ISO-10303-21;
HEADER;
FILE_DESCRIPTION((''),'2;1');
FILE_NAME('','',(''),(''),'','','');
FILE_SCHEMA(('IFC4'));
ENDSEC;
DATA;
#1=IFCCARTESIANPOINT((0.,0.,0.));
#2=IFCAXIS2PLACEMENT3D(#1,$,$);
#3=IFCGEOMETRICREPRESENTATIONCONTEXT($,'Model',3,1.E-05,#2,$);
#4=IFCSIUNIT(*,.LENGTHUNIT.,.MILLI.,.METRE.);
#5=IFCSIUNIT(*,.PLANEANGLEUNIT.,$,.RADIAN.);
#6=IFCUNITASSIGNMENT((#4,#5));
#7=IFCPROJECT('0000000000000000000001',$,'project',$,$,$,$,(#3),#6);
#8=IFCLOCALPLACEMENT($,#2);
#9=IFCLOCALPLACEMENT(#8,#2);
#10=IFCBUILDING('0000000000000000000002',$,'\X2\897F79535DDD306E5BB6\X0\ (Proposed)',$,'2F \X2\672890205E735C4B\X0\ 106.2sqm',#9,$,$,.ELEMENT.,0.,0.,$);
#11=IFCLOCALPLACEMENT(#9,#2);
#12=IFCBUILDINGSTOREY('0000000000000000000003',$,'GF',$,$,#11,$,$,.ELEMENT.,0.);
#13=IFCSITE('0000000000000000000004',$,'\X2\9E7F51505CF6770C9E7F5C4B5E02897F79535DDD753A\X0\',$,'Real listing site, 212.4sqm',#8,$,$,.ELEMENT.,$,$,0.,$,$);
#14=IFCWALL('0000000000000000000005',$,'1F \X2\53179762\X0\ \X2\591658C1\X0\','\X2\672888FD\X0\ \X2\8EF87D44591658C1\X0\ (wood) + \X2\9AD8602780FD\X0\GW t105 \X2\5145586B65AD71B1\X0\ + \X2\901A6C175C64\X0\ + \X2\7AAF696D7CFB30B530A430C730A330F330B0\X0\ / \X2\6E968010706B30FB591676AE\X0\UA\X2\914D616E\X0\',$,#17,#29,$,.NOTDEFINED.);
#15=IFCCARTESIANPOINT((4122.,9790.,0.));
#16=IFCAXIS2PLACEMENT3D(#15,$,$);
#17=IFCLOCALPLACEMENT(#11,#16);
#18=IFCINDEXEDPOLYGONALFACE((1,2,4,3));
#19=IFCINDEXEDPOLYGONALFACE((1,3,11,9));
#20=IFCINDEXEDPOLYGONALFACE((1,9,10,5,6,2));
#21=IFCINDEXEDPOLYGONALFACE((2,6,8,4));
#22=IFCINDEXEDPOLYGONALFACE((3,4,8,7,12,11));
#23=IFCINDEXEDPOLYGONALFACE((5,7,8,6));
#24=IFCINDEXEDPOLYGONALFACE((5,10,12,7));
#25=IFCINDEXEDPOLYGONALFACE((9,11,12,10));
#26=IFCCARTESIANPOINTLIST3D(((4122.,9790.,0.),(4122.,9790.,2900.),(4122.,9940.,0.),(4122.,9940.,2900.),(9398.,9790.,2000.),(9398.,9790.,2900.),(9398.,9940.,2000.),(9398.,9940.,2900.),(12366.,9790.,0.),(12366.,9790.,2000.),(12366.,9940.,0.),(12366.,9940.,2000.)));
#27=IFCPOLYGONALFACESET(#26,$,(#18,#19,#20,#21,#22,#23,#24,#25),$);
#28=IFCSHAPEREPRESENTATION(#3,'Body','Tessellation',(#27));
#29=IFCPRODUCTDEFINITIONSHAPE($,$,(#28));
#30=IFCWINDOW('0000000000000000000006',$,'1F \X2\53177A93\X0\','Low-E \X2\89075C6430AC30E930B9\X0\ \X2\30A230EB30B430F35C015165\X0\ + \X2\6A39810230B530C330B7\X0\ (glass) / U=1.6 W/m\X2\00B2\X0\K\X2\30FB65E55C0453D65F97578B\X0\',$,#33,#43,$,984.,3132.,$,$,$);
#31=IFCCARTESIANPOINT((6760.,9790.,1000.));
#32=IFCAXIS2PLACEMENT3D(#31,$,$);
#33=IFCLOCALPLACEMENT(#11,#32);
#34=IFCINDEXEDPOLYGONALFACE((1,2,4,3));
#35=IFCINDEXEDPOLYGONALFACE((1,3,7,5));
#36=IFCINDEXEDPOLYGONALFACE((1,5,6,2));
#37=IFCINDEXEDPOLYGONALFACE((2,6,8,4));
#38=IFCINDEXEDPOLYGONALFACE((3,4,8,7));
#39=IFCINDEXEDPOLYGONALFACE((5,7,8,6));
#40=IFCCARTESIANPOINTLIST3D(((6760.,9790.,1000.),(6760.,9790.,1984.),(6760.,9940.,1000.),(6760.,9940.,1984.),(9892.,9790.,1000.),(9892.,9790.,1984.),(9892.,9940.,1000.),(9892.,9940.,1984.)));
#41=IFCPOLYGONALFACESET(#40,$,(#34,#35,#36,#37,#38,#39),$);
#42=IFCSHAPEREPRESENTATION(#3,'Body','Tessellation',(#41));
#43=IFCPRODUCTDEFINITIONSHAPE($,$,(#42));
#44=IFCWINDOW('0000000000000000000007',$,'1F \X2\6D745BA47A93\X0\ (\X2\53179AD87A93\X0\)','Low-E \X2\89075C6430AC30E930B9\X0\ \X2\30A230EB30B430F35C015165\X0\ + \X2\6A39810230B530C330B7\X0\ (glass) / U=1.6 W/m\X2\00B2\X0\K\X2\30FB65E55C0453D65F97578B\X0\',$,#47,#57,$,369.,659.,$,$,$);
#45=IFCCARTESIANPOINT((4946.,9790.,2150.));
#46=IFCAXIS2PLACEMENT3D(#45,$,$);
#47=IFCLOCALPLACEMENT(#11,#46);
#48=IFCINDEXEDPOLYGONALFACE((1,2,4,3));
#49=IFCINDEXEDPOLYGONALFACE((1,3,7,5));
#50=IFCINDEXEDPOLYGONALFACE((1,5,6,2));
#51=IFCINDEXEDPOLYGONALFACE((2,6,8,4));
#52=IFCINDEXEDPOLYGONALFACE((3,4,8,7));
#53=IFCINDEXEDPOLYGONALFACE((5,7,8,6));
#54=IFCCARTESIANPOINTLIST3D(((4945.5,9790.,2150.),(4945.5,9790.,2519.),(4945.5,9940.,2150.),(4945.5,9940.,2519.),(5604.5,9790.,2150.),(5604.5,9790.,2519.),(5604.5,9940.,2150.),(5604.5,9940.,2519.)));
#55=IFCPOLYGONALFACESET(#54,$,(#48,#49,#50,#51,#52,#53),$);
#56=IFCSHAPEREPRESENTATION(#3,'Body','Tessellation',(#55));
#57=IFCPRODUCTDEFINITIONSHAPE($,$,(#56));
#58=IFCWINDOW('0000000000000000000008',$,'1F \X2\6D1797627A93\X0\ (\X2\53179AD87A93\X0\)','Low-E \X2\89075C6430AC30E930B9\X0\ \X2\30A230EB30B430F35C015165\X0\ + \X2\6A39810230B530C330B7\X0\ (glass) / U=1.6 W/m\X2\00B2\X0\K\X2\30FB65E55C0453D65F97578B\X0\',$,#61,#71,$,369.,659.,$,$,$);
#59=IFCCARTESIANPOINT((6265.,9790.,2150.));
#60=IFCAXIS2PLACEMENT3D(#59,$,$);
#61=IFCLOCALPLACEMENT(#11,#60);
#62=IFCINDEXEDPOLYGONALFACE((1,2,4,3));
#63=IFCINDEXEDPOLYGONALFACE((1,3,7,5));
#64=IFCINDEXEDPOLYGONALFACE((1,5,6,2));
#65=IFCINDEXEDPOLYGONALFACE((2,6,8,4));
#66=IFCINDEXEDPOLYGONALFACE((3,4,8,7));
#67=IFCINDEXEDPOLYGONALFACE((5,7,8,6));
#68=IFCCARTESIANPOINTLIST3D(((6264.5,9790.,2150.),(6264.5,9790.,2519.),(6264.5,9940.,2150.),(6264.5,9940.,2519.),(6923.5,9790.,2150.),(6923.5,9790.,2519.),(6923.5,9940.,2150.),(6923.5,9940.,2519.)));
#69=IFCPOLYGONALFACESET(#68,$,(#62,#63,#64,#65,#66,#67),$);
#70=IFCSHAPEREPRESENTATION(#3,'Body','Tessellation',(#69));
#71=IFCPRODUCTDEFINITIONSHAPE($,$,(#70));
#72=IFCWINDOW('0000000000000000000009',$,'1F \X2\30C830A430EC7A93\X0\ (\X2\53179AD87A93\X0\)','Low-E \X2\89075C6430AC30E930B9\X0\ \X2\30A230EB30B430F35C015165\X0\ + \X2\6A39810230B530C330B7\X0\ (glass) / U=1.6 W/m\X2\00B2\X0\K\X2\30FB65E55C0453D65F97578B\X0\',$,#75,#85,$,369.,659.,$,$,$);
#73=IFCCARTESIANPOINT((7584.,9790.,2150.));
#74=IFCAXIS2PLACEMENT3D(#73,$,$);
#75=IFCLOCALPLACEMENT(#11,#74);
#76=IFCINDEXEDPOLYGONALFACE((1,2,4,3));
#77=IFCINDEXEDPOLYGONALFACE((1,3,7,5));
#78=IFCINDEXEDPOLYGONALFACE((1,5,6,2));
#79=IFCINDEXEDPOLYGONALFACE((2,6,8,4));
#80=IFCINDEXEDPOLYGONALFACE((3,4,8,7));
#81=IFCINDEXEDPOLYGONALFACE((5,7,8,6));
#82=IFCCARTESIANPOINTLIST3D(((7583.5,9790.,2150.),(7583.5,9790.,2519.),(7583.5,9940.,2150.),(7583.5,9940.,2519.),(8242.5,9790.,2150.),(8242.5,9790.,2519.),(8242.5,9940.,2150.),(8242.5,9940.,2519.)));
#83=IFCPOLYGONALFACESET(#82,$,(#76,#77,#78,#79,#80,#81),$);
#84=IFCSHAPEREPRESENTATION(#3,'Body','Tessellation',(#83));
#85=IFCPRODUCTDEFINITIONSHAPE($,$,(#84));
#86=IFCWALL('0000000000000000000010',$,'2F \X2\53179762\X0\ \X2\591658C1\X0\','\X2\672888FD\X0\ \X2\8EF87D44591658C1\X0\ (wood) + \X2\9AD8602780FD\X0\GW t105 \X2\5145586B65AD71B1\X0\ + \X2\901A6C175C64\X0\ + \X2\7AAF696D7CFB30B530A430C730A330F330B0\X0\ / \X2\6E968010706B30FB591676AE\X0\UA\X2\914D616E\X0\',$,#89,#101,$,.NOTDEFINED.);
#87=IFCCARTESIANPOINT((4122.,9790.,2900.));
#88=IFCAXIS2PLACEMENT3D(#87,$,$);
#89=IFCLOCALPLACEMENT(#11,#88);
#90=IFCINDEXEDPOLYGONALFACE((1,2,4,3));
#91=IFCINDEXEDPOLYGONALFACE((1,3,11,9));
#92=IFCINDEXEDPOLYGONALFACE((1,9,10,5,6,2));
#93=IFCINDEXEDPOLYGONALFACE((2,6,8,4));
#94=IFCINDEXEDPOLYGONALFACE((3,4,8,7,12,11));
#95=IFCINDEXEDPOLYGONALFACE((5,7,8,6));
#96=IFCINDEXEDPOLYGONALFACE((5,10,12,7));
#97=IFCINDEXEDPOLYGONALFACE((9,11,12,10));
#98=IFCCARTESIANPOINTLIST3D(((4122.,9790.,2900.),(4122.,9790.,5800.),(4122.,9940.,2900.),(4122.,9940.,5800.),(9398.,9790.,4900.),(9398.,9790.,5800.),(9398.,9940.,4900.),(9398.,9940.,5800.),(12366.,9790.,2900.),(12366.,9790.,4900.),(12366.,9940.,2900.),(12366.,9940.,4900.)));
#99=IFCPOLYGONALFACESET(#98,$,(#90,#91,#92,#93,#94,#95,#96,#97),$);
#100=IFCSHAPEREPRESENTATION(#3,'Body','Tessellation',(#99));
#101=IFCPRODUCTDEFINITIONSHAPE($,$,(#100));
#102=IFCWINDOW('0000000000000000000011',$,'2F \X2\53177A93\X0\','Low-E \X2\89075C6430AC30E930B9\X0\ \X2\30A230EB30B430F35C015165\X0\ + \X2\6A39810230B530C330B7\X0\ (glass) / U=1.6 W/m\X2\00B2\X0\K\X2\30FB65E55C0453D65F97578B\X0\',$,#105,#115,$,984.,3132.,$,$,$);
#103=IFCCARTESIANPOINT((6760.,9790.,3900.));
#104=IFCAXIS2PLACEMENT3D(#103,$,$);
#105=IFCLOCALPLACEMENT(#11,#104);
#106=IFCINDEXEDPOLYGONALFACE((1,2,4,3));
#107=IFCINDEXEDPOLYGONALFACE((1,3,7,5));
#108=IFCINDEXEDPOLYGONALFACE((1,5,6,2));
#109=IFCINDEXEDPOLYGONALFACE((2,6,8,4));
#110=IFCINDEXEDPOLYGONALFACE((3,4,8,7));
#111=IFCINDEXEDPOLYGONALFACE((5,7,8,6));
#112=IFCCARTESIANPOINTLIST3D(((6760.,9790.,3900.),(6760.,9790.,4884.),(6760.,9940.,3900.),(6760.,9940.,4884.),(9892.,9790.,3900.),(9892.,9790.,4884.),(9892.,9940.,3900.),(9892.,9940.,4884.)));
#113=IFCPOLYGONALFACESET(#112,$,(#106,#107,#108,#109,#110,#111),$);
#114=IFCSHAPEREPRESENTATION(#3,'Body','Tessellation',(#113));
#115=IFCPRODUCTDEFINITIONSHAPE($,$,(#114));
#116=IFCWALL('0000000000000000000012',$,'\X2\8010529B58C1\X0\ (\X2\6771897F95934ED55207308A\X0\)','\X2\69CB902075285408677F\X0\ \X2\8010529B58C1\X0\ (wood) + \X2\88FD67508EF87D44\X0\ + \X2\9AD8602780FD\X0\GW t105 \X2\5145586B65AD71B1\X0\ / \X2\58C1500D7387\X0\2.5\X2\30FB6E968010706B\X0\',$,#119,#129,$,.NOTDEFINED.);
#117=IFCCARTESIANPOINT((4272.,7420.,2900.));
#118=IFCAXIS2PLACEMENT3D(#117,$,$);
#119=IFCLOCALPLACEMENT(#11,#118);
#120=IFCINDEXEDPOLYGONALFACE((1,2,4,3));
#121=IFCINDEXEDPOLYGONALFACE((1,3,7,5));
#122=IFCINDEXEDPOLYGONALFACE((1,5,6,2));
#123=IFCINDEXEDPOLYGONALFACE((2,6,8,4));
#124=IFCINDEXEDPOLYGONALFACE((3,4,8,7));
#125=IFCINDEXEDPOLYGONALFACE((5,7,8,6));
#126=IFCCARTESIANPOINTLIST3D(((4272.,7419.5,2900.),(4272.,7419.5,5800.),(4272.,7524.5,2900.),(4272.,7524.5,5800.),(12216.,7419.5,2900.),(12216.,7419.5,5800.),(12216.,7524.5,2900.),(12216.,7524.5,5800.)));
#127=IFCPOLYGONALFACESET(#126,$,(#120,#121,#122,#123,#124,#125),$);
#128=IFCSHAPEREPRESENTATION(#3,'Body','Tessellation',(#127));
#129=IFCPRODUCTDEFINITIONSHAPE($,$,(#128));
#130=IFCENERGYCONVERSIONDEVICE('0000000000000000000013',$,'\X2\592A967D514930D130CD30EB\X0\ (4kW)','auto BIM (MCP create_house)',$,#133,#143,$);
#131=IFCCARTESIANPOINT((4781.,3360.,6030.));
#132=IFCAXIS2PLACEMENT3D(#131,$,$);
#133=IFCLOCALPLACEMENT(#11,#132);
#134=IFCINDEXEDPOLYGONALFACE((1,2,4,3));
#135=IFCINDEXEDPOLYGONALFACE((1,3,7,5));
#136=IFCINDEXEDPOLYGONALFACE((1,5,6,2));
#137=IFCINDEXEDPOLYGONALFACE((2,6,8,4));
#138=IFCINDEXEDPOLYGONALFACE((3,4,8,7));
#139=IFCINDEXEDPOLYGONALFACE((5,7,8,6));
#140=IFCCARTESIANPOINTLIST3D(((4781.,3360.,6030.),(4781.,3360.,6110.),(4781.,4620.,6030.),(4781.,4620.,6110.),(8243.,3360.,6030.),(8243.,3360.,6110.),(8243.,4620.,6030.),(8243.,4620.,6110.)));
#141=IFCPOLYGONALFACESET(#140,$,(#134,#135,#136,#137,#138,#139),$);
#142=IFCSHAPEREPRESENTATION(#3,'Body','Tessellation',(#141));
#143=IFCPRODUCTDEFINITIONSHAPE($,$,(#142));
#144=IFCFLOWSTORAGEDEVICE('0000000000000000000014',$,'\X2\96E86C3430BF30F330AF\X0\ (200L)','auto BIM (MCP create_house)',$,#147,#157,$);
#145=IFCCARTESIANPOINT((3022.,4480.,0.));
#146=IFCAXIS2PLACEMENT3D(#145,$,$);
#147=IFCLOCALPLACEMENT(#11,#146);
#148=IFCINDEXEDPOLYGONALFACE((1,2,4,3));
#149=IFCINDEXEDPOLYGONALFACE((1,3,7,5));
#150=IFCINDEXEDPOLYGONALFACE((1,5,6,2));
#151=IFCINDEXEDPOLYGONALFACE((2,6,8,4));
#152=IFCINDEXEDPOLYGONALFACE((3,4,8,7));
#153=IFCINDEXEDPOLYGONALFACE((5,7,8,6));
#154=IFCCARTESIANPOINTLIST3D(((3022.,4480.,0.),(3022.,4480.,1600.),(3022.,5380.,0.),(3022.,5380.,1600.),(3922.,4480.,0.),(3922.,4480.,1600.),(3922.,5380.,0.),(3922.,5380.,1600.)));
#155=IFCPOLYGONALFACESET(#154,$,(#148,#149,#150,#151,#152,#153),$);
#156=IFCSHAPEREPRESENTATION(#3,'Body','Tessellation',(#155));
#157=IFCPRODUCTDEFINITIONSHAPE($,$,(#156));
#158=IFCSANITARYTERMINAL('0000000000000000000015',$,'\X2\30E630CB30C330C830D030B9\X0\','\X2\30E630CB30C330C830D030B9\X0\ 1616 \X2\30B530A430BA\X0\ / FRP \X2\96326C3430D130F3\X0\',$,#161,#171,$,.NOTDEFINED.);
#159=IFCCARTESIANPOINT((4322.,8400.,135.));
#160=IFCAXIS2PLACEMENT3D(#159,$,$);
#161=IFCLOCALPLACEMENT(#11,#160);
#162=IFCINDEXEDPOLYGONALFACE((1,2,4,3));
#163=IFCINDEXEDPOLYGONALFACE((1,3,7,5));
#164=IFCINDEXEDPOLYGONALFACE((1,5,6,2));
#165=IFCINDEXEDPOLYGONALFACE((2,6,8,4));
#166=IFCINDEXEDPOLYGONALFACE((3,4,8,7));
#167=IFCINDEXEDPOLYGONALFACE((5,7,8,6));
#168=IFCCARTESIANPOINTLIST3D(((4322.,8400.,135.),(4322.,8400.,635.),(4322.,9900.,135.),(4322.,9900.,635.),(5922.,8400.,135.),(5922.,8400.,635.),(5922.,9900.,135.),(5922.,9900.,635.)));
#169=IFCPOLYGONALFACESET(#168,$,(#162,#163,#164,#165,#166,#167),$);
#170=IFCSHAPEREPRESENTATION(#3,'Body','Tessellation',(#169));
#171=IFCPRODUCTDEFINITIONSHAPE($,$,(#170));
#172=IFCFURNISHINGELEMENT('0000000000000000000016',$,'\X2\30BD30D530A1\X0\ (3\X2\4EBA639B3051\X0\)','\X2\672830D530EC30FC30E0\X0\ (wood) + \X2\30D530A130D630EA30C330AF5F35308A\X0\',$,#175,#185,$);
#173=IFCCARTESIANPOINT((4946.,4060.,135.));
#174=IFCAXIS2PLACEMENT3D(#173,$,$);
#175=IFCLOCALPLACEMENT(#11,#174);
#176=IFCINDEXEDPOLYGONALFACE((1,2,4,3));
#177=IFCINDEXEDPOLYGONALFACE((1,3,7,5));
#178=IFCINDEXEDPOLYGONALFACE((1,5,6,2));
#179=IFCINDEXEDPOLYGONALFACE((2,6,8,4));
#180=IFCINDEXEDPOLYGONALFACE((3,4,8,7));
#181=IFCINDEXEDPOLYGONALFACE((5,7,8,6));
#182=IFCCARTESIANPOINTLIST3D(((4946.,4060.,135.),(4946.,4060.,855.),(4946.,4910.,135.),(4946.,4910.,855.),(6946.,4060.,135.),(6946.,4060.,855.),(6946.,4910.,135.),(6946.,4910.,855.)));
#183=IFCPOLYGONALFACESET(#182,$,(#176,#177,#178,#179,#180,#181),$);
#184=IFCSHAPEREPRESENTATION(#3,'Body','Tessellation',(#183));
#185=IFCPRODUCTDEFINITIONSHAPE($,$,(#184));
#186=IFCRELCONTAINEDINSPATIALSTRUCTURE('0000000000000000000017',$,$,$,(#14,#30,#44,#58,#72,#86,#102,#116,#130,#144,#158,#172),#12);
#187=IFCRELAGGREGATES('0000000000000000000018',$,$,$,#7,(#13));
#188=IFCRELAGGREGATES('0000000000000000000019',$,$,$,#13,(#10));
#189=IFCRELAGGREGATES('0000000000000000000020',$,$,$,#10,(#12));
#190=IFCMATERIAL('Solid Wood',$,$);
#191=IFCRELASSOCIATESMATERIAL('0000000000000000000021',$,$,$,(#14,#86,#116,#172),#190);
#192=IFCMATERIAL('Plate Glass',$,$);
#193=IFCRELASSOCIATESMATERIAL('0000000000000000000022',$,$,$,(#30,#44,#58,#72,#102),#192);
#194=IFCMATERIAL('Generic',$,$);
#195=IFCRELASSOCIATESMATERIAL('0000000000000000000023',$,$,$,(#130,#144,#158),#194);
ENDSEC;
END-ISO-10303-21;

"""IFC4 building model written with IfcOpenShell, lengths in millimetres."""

from ifc_helpers import new_model, si_unit, frame, frame_2d, origin, place, context, project, spatial, rectangle, extrude, material, element, fill, save


model = new_model("IFC4")

# Units and contexts
model_context = context("Model", 3, precision=1e-05, world=origin())
ifc_project = project(units=[si_unit("LENGTHUNIT", "METRE", prefix="MILLI"), si_unit("PLANEANGLEUNIT", "RADIAN")], contexts=[model_context])

# Site, building, storey
site_placement = place(None, origin())
site = spatial("IfcSite", under=ifc_project, at=site_placement, Name="鹿児島県鹿屋市西祓川町", ObjectType="Real listing site, 212.4sqm", CompositionType="ELEMENT", RefElevation=0.0)
building_placement = place(site_placement, origin())
building = spatial("IfcBuilding", under=site, at=building_placement, Name="西祓川の家 (Proposed)", ObjectType="2F 木造平屋 106.2sqm", CompositionType="ELEMENT", ElevationOfRefHeight=0.0, ElevationOfTerrain=0.0)
storey_placement = place(building_placement, origin())
storey = spatial("IfcBuildingStorey", under=building, at=storey_placement, Name="GF", CompositionType="ELEMENT", Elevation=0.0)

# Wall, openings, windows
ifc_material_1 = material(Name="Solid Wood")
wall_1_placement = place(storey_placement, frame((4122.0, 9790.0, 0.0)))
wall_1 = element("IfcWall", 1, at=wall_1_placement, inside=storey, material=ifc_material_1, Name="1F 北面 外壁", Description="木製 軸組外壁 (wood) + 高性能GW t105 充填断熱 + 通気層 + 窯業系サイディング / 準耐火・外皮UA配慮", PredefinedType="NOTDEFINED", context=model_context, shape_type="SweptSolid", body=[
    extrude(rectangle(XDim=8244.0, YDim=150.0, at=frame_2d((4122.0, 75.0))), frame((4122.0, 9790.0, 0.0)), (0.0, 0.0, 1.0), 2900.0),
])
opening_1_placement = place(storey_placement, frame((6760.0, 9790.0, 1000.0)))
opening_1 = element("IfcOpeningElement", 2, at=opening_1_placement, cuts=wall_1, PredefinedType="NOTDEFINED", context=model_context, shape_type="SweptSolid", body=[
    extrude(rectangle(XDim=3132.0, YDim=150.0, at=frame_2d((1566.0, 75.0))), frame((6760.0, 9790.0, 1000.0)), (0.0, 0.0, 1.0), 984.0),
])
opening_2_placement = place(storey_placement, frame((4946.0, 9790.0, 2150.0)))
opening_2 = element("IfcOpeningElement", 3, at=opening_2_placement, cuts=wall_1, PredefinedType="NOTDEFINED", context=model_context, shape_type="SweptSolid", body=[
    extrude(rectangle(XDim=659.0, YDim=150.0, at=frame_2d((329.0, 75.0))), frame((4946.0, 9790.0, 2150.0)), (0.0, 0.0, 1.0), 369.0),
])
opening_3_placement = place(storey_placement, frame((6265.0, 9790.0, 2150.0)))
opening_3 = element("IfcOpeningElement", 4, at=opening_3_placement, cuts=wall_1, PredefinedType="NOTDEFINED", context=model_context, shape_type="SweptSolid", body=[
    extrude(rectangle(XDim=659.0, YDim=150.0, at=frame_2d((329.0, 75.0))), frame((6265.0, 9790.0, 2150.0)), (0.0, 0.0, 1.0), 369.0),
])
opening_4_placement = place(storey_placement, frame((7584.0, 9790.0, 2150.0)))
opening_4 = element("IfcOpeningElement", 5, at=opening_4_placement, cuts=wall_1, PredefinedType="NOTDEFINED", context=model_context, shape_type="SweptSolid", body=[
    extrude(rectangle(XDim=659.0, YDim=150.0, at=frame_2d((329.0, 75.0))), frame((7584.0, 9790.0, 2150.0)), (0.0, 0.0, 1.0), 369.0),
])
ifc_material_2 = material(Name="Plate Glass")
window_1_placement = place(storey_placement, frame((6760.0, 9790.0, 1000.0)))
window_1 = element("IfcWindow", 6, at=window_1_placement, inside=storey, material=ifc_material_2, Name="1F 北窓", Description="Low-E 複層ガラス アルゴン封入 + 樹脂サッシ (glass) / U=1.6 W/m²K・日射取得型", OverallHeight=984.0, OverallWidth=3132.0, context=model_context, shape_type="SweptSolid", body=[
    extrude(rectangle(XDim=3132.0, YDim=150.0, at=frame_2d((1566.0, 75.0))), frame((6760.0, 9790.0, 1000.0)), (0.0, 0.0, 1.0), 984.0),
])
fill(opening_1, window_1)
window_2_placement = place(storey_placement, frame((4946.0, 9790.0, 2150.0)))
window_2 = element("IfcWindow", 7, at=window_2_placement, inside=storey, material=ifc_material_2, Name="1F 浴室窓 (北高窓)", Description="Low-E 複層ガラス アルゴン封入 + 樹脂サッシ (glass) / U=1.6 W/m²K・日射取得型", OverallHeight=369.0, OverallWidth=659.0, context=model_context, shape_type="SweptSolid", body=[
    extrude(rectangle(XDim=659.0, YDim=150.0, at=frame_2d((329.0, 75.0))), frame((4946.0, 9790.0, 2150.0)), (0.0, 0.0, 1.0), 369.0),
])
fill(opening_2, window_2)
window_3_placement = place(storey_placement, frame((6265.0, 9790.0, 2150.0)))
window_3 = element("IfcWindow", 8, at=window_3_placement, inside=storey, material=ifc_material_2, Name="1F 洗面窓 (北高窓)", Description="Low-E 複層ガラス アルゴン封入 + 樹脂サッシ (glass) / U=1.6 W/m²K・日射取得型", OverallHeight=369.0, OverallWidth=659.0, context=model_context, shape_type="SweptSolid", body=[
    extrude(rectangle(XDim=659.0, YDim=150.0, at=frame_2d((329.0, 75.0))), frame((6265.0, 9790.0, 2150.0)), (0.0, 0.0, 1.0), 369.0),
])
fill(opening_3, window_3)
window_4_placement = place(storey_placement, frame((7584.0, 9790.0, 2150.0)))
window_4 = element("IfcWindow", 9, at=window_4_placement, inside=storey, material=ifc_material_2, Name="1F トイレ窓 (北高窓)", Description="Low-E 複層ガラス アルゴン封入 + 樹脂サッシ (glass) / U=1.6 W/m²K・日射取得型", OverallHeight=369.0, OverallWidth=659.0, context=model_context, shape_type="SweptSolid", body=[
    extrude(rectangle(XDim=659.0, YDim=150.0, at=frame_2d((329.0, 75.0))), frame((7584.0, 9790.0, 2150.0)), (0.0, 0.0, 1.0), 369.0),
])
fill(opening_4, window_4)

# Wall, opening, window
wall_2_placement = place(storey_placement, frame((4122.0, 9790.0, 2900.0)))
wall_2 = element("IfcWall", 10, at=wall_2_placement, inside=storey, material=ifc_material_1, Name="2F 北面 外壁", Description="木製 軸組外壁 (wood) + 高性能GW t105 充填断熱 + 通気層 + 窯業系サイディング / 準耐火・外皮UA配慮", PredefinedType="NOTDEFINED", context=model_context, shape_type="SweptSolid", body=[
    extrude(rectangle(XDim=8244.0, YDim=150.0, at=frame_2d((4122.0, 75.0))), frame((4122.0, 9790.0, 2900.0)), (0.0, 0.0, 1.0), 2900.0),
])
opening_5_placement = place(storey_placement, frame((6760.0, 9790.0, 3900.0)))
opening_5 = element("IfcOpeningElement", 11, at=opening_5_placement, cuts=wall_2, PredefinedType="NOTDEFINED", context=model_context, shape_type="SweptSolid", body=[
    extrude(rectangle(XDim=3132.0, YDim=150.0, at=frame_2d((1566.0, 75.0))), frame((6760.0, 9790.0, 3900.0)), (0.0, 0.0, 1.0), 984.0),
])
window_5_placement = place(storey_placement, frame((6760.0, 9790.0, 3900.0)))
window_5 = element("IfcWindow", 12, at=window_5_placement, inside=storey, material=ifc_material_2, Name="2F 北窓", Description="Low-E 複層ガラス アルゴン封入 + 樹脂サッシ (glass) / U=1.6 W/m²K・日射取得型", OverallHeight=984.0, OverallWidth=3132.0, context=model_context, shape_type="SweptSolid", body=[
    extrude(rectangle(XDim=3132.0, YDim=150.0, at=frame_2d((1566.0, 75.0))), frame((6760.0, 9790.0, 3900.0)), (0.0, 0.0, 1.0), 984.0),
])
fill(opening_5, window_5)

# Wall
wall_3_placement = place(storey_placement, frame((4272.0, 7420.0, 2900.0)))
element("IfcWall", 13, at=wall_3_placement, inside=storey, material=ifc_material_1, Name="耐力壁 (東西間仕切り)", Description="構造用合板 耐力壁 (wood) + 製材軸組 + 高性能GW t105 充填断熱 / 壁倍率2.5・準耐火", PredefinedType="NOTDEFINED", context=model_context, shape_type="SweptSolid", body=[
    extrude(rectangle(XDim=7944.0, YDim=105.0, at=frame_2d((3972.0, 52.0))), frame((4272.0, 7420.0, 2900.0)), (0.0, 0.0, 1.0), 2900.0),
])

# Energy conversion device
ifc_material_3 = material(Name="Generic")
energy_conversion_device_placement = place(storey_placement, frame((4781.0, 3360.0, 6030.0)))
element("IfcEnergyConversionDevice", 14, at=energy_conversion_device_placement, inside=storey, material=ifc_material_3, Name="太陽光パネル (4kW)", Description="auto BIM (MCP create_house)", context=model_context, shape_type="SweptSolid", body=[
    extrude(rectangle(XDim=3462.0, YDim=1260.0, at=frame_2d((1731.0, 630.0))), frame((4781.0, 3360.0, 6030.0)), (0.0, 0.0, 1.0), 80.0),
])

# Flow storage device
flow_storage_device_placement = place(storey_placement, frame((3022.0, 4480.0, 0.0)))
element("IfcFlowStorageDevice", 15, at=flow_storage_device_placement, inside=storey, material=ifc_material_3, Name="雨水タンク (200L)", Description="auto BIM (MCP create_house)", context=model_context, shape_type="SweptSolid", body=[
    extrude(rectangle(XDim=900.0, YDim=900.0, at=frame_2d((450.0, 450.0))), frame((3022.0, 4480.0, 0.0)), (0.0, 0.0, 1.0), 1600.0),
])

# Sanitary terminal
sanitary_terminal_placement = place(storey_placement, frame((4322.0, 8400.0, 135.0)))
element("IfcSanitaryTerminal", 16, at=sanitary_terminal_placement, inside=storey, material=ifc_material_3, Name="ユニットバス", Description="ユニットバス 1616 サイズ / FRP 防水パン", PredefinedType="NOTDEFINED", context=model_context, shape_type="SweptSolid", body=[
    extrude(rectangle(XDim=1600.0, YDim=1500.0, at=frame_2d((800.0, 750.0))), frame((4322.0, 8400.0, 135.0)), (0.0, 0.0, 1.0), 500.0),
])

# Furnishing element
furnishing_1_placement = place(storey_placement, frame((4946.0, 4060.0, 135.0)))
element("IfcFurnishingElement", 17, at=furnishing_1_placement, inside=storey, material=ifc_material_1, Name="ソファ (3人掛け)", Description="木フレーム (wood) + ファブリック張り", context=model_context, shape_type="SweptSolid", body=[
    extrude(rectangle(XDim=2000.0, YDim=850.0, at=frame_2d((1000.0, 425.0))), frame((4946.0, 4060.0, 135.0)), (0.0, 0.0, 1.0), 720.0),
])

save(model, "model.ifc")
